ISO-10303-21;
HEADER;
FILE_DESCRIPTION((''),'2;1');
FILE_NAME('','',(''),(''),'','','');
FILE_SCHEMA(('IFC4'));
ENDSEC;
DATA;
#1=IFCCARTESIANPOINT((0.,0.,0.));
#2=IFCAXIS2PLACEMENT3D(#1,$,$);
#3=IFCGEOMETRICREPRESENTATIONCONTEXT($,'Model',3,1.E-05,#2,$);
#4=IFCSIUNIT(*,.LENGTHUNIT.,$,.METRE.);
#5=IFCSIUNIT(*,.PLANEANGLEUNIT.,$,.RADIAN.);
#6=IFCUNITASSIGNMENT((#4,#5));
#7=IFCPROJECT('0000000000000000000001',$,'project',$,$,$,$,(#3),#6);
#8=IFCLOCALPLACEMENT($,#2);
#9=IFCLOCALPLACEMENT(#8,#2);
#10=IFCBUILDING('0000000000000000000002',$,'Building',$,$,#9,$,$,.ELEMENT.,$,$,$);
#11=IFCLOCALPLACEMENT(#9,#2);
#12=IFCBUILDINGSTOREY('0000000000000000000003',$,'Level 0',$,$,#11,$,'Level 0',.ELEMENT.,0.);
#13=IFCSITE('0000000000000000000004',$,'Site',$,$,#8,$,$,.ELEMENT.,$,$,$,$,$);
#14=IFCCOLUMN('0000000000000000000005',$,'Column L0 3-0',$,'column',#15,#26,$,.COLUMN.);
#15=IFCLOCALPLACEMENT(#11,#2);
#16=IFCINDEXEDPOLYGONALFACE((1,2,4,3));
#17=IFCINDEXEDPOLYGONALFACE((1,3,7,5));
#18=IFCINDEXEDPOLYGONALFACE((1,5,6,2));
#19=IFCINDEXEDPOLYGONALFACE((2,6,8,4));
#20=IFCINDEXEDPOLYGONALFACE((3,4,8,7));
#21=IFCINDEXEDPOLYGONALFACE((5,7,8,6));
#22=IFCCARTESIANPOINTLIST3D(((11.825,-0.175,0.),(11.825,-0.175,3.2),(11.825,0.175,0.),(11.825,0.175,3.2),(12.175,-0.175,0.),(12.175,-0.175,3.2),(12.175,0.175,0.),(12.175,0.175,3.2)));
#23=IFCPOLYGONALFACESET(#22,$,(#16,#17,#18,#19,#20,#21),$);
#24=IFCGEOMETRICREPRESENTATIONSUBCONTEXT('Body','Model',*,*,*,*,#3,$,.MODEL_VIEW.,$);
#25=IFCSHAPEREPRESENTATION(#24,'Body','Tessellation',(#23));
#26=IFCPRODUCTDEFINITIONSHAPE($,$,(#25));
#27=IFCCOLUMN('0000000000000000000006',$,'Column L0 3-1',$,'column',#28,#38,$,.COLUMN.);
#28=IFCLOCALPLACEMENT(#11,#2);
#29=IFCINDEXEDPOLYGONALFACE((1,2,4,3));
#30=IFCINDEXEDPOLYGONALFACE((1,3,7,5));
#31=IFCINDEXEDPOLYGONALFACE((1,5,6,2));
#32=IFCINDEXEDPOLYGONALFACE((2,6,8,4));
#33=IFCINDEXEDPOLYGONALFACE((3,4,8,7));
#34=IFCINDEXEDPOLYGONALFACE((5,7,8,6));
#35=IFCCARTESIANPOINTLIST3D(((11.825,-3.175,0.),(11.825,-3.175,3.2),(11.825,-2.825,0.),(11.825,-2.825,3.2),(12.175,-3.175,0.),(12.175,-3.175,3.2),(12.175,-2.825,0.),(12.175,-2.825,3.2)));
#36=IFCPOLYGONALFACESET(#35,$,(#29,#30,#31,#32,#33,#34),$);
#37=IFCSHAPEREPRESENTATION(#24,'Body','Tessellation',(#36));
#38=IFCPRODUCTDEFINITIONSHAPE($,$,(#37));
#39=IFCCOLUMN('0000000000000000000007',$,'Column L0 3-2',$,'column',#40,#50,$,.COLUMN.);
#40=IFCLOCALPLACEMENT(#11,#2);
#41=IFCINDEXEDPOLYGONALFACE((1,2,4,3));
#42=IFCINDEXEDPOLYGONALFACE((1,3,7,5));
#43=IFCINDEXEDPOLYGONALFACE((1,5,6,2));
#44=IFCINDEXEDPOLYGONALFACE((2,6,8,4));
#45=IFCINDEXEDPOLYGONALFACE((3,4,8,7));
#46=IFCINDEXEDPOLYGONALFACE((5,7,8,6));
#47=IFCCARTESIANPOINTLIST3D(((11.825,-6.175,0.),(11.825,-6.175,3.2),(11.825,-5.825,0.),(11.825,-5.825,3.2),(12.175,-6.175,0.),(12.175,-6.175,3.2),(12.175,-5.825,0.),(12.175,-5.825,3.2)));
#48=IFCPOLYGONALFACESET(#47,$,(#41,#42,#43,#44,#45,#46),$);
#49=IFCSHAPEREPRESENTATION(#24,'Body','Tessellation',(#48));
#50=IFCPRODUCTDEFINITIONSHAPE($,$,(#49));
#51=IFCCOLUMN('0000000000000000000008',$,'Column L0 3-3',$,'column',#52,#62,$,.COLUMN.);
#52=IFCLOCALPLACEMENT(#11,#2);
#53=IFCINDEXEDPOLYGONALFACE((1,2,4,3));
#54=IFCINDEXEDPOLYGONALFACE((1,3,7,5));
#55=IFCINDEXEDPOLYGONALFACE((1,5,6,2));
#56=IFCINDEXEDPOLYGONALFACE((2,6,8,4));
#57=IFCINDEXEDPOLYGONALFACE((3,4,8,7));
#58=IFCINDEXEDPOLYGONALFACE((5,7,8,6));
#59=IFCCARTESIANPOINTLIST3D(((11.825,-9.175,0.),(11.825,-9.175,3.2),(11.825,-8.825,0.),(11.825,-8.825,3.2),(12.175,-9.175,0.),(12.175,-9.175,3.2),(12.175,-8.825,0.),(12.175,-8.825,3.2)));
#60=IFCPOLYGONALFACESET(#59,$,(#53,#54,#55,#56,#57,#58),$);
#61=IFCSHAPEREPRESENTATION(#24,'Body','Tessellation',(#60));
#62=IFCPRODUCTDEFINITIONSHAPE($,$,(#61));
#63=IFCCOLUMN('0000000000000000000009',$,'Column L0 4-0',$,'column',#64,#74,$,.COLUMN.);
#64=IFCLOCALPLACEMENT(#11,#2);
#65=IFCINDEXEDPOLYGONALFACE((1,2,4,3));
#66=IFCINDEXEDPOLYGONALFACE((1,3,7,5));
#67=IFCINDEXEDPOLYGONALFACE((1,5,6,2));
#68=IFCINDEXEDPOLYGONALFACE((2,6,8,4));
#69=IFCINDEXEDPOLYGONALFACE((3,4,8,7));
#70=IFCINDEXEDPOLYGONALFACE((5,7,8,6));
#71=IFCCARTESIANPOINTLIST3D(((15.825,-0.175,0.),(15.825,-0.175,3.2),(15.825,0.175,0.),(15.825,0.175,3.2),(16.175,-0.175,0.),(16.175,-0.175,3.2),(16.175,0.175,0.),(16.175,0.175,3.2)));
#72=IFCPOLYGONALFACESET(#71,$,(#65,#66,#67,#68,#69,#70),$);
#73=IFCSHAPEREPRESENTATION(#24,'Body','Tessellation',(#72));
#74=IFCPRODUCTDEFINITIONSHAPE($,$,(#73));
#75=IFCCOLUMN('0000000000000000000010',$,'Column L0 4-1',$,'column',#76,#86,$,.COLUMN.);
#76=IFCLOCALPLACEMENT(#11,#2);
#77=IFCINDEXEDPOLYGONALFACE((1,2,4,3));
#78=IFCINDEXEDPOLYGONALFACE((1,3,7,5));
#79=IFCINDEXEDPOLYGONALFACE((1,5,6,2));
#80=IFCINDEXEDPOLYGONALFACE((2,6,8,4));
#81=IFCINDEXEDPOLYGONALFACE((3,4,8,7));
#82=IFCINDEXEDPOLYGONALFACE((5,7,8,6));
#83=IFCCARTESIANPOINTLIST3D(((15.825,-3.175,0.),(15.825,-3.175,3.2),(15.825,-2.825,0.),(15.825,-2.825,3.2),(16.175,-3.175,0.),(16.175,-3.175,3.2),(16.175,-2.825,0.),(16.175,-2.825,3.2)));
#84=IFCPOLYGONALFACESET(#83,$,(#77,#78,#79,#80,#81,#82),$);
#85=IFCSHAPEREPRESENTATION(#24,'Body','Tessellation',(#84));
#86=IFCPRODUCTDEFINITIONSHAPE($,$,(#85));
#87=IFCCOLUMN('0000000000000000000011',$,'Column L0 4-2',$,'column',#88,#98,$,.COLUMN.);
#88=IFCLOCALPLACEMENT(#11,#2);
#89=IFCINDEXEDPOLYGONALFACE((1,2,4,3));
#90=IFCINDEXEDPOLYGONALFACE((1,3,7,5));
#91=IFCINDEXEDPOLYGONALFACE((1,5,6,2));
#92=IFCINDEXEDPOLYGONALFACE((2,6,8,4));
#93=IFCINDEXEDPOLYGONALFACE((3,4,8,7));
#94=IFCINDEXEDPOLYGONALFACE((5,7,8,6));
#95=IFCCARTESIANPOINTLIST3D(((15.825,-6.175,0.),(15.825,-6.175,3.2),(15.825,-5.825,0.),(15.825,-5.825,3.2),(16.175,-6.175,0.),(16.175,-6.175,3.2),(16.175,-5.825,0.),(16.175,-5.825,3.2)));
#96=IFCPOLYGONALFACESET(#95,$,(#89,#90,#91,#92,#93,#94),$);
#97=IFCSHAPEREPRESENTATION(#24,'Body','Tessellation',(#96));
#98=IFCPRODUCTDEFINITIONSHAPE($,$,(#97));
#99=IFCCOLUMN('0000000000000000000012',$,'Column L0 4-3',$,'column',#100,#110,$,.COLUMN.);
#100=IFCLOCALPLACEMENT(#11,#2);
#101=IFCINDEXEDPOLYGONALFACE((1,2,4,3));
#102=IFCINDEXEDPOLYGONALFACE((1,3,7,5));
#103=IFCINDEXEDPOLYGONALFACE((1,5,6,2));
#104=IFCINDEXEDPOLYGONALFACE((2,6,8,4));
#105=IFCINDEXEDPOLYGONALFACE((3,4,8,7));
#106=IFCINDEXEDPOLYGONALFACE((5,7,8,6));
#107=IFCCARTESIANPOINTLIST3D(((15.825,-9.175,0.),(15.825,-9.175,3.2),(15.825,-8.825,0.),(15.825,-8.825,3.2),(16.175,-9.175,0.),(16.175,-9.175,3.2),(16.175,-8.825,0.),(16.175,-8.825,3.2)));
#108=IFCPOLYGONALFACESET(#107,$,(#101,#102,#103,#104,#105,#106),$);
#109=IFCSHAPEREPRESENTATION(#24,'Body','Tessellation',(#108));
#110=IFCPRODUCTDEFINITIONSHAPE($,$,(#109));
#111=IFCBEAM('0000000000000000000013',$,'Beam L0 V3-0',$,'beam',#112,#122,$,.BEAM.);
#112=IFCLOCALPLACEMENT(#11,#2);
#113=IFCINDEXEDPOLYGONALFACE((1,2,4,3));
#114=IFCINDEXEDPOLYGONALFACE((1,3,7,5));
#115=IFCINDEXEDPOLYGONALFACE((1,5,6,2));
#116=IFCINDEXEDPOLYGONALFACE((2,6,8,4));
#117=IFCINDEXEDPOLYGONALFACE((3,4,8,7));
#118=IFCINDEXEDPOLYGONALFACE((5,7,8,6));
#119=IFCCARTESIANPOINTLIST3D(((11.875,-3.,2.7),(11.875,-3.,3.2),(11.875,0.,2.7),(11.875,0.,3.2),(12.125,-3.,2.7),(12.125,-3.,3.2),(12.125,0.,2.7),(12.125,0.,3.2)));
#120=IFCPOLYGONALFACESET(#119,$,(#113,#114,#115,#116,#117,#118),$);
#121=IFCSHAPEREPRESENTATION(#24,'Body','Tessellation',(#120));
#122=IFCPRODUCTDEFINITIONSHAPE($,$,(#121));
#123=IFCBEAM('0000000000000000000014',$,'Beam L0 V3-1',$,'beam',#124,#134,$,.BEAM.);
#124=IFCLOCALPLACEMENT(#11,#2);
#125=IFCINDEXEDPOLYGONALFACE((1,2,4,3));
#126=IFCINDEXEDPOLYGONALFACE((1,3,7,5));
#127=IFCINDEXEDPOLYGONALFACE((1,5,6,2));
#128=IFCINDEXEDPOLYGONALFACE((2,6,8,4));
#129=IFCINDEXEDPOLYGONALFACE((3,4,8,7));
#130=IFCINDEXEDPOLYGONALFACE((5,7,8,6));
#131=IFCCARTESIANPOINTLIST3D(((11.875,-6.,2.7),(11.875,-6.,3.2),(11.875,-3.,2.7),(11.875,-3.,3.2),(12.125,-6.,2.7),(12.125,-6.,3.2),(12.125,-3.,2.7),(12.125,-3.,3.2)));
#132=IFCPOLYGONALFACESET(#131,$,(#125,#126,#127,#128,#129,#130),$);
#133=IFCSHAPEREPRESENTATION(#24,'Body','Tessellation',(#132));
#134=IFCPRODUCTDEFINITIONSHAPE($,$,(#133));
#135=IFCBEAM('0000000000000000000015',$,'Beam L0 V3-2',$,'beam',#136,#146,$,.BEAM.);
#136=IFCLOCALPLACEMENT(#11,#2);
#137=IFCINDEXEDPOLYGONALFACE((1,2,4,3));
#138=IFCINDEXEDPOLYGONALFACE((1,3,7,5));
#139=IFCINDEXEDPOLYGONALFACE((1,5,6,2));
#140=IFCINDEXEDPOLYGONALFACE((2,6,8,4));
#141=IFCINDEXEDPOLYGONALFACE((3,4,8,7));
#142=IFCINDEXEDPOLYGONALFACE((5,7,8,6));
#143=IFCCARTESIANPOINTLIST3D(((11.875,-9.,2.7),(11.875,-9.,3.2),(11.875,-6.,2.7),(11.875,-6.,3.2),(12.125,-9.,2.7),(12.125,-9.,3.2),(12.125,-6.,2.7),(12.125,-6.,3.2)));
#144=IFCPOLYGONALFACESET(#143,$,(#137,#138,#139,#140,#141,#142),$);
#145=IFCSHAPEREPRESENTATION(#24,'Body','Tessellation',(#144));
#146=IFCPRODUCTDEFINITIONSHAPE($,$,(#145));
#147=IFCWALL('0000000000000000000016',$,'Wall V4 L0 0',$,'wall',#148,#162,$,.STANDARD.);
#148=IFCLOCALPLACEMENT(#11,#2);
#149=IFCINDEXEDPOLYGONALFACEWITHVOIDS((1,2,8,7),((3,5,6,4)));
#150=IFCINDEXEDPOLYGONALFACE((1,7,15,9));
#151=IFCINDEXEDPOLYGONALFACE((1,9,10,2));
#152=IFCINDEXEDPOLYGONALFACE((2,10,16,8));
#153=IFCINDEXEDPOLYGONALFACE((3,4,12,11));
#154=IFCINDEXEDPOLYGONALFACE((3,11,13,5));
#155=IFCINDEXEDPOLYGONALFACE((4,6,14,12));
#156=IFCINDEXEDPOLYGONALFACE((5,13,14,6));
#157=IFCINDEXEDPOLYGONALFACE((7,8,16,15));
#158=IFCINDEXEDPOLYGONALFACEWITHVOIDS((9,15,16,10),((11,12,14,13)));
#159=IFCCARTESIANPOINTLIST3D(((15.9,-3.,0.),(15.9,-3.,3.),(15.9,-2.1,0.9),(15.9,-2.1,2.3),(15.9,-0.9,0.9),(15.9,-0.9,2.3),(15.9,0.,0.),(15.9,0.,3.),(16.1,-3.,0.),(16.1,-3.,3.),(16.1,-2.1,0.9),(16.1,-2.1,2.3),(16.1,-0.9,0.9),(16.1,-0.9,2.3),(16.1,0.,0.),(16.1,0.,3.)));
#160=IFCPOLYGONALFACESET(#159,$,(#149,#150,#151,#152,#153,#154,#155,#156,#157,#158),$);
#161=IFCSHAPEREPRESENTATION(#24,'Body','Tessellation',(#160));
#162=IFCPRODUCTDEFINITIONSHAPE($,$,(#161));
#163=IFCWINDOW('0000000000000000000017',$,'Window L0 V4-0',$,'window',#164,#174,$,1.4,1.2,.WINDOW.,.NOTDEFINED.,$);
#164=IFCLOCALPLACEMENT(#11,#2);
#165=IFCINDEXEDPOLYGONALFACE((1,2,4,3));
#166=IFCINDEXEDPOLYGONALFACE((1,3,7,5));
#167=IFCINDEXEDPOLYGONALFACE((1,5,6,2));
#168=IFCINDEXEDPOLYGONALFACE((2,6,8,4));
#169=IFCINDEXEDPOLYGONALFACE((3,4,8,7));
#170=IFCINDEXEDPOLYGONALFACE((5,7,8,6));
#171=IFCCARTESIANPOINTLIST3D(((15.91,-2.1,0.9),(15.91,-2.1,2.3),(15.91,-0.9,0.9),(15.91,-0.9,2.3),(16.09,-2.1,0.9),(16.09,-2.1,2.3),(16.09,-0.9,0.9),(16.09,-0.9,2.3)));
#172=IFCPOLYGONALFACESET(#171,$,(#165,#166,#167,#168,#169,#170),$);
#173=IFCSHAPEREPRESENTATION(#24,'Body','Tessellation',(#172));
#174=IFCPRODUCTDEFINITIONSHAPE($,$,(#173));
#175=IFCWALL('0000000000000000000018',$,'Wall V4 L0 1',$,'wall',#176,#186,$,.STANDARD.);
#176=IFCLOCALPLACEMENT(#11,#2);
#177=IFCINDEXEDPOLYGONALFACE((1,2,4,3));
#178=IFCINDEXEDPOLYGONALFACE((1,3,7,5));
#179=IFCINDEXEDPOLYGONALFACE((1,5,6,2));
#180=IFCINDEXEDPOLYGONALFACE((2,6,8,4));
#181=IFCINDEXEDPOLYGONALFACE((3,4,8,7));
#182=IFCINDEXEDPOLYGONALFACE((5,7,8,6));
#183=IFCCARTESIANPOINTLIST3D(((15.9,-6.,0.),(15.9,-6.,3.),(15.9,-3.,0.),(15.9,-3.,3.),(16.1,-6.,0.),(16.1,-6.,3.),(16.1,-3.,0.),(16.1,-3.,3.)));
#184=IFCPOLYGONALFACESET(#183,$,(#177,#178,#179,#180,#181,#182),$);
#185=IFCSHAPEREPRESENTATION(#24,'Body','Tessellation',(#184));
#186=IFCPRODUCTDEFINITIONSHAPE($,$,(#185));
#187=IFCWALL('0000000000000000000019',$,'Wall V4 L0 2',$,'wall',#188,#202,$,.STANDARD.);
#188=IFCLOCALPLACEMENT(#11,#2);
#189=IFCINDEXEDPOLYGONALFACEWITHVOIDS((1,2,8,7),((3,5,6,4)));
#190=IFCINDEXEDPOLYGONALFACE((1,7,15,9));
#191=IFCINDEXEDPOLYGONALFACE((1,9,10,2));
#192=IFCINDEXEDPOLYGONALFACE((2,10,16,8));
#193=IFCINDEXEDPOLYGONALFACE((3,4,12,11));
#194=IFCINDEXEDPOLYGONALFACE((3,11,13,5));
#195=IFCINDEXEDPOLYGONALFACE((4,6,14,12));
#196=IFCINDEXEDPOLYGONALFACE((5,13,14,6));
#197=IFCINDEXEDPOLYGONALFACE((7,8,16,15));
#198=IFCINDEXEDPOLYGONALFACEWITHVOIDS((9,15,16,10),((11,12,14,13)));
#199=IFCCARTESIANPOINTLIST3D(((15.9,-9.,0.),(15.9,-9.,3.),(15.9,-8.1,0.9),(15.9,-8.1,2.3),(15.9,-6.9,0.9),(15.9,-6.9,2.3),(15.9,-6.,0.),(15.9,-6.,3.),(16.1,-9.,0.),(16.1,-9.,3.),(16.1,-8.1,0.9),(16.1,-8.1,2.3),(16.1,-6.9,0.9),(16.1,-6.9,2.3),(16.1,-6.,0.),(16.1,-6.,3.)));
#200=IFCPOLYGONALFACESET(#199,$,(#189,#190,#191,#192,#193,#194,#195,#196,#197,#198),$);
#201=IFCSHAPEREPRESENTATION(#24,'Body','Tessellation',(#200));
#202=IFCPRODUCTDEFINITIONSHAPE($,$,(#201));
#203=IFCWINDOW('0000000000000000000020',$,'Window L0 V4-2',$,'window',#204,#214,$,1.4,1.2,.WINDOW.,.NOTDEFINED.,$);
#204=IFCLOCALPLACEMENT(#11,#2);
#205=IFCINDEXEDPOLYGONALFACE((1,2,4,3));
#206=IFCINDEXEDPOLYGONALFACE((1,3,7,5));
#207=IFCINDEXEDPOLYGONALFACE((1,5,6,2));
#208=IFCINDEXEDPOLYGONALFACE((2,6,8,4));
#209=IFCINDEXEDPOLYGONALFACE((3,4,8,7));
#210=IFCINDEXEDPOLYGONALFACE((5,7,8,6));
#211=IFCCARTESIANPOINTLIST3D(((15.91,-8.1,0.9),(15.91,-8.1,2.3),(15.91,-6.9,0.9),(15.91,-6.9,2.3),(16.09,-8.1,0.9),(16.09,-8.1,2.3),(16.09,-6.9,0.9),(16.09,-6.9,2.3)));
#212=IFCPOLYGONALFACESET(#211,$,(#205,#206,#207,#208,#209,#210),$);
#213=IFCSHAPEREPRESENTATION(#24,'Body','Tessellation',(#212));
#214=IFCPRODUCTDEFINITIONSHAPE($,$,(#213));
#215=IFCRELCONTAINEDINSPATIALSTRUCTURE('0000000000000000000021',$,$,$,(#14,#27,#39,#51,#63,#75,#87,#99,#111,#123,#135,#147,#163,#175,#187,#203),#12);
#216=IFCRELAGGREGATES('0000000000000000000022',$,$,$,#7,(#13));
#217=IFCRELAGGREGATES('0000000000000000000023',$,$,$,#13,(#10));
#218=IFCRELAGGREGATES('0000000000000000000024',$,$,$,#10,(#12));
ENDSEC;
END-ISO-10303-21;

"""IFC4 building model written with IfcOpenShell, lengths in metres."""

from ifc_helpers import new_model, si_unit, frame, frame_2d, origin, origin_2d, place, context, subcontext, project, spatial, rectangle, extrude, element, fill, save


model = new_model("IFC4")

# Units and contexts
model_context = context("Model", 3, precision=1e-05, world=origin())
body_context = subcontext(model_context, "Body", "Model", "MODEL_VIEW")
ifc_project = project(units=[si_unit("LENGTHUNIT", "METRE"), si_unit("PLANEANGLEUNIT", "RADIAN")], contexts=[model_context])

# Site, building, storey
site_placement = place(None, origin())
site = spatial("IfcSite", under=ifc_project, at=site_placement, Name="Site", CompositionType="ELEMENT")
building_placement = place(site_placement, origin())
building = spatial("IfcBuilding", under=site, at=building_placement, Name="Building", CompositionType="ELEMENT")
storey_placement = place(building_placement, origin())
storey = spatial("IfcBuildingStorey", under=building, at=storey_placement, Name="Level 0", LongName="Level 0", CompositionType="ELEMENT", Elevation=0.0)

# Columns
for number, where, name in (
    (1, (12.0, 0.0, 0.0), "Column L0 3-0"),
    (2, (12.0, -3.0, 0.0), "Column L0 3-1"),
    (3, (12.0, -6.0, 0.0), "Column L0 3-2"),
    (4, (12.0, -9.0, 0.0), "Column L0 3-3"),
    (5, (16.0, 0.0, 0.0), "Column L0 4-0"),
    (6, (16.0, -3.0, 0.0), "Column L0 4-1"),
    (7, (16.0, -6.0, 0.0), "Column L0 4-2"),
    (8, (16.0, -9.0, 0.0), "Column L0 4-3"),
):
    element("IfcColumn", number, at=place(storey_placement, frame(where)), inside=storey, Name=name, ObjectType="column", PredefinedType="COLUMN", context=body_context, shape_type="SweptSolid", body=[
        extrude(rectangle(XDim=0.35, YDim=0.35, at=origin_2d()), origin(), (0.0, 0.0, 1.0), 3.2),
    ])

# Beams
for number, where, z_axis, x_axis, name in (
    (9, (12.0, 0.0, 2.95), (0.0, -1.0, 0.0), (0.0, 0.0, 1.0), "Beam L0 V3-0"),
    (10, (12.0, -3.0, 2.95), (0.0, -1.0, 0.0), (0.0, 0.0, 1.0), "Beam L0 V3-1"),
    (11, (12.0, -6.0, 2.95), (0.0, -1.0, 0.0), (0.0, 0.0, 1.0), "Beam L0 V3-2"),
):
    element("IfcBeam", number, at=place(storey_placement, frame(where, z_axis=z_axis, x_axis=x_axis)), inside=storey, Name=name, ObjectType="beam", PredefinedType="BEAM", context=body_context, shape_type="SweptSolid", body=[
        extrude(rectangle(XDim=0.5, YDim=0.25, at=origin_2d()), origin(), (0.0, 0.0, 1.0), 3.0),
    ])

# Wall, opening, window
wall_1_placement = place(storey_placement, frame((16.0, 0.0, 0.0), z_axis=(0.0, 0.0, 1.0), x_axis=(0.0, -1.0, 0.0)))
wall_1 = element("IfcWall", 12, at=wall_1_placement, inside=storey, Name="Wall V4 L0 0", ObjectType="wall", PredefinedType="STANDARD", context=body_context, shape_type="SweptSolid", body=[
    extrude(rectangle(XDim=3.0, YDim=0.2, at=frame_2d((1.5, 0.0))), origin(), (0.0, 0.0, 1.0), 3.0),
])
opening_1_placement = place(storey_placement, frame((16.0, -1.5, 0.9), z_axis=(0.0, 0.0, 1.0), x_axis=(0.0, -1.0, 0.0)))
opening_1 = element("IfcOpeningElement", 13, at=opening_1_placement, cuts=wall_1, ObjectType="Opening", PredefinedType="OPENING", context=body_context, shape_type="SweptSolid", body=[
    extrude(rectangle(XDim=1.2, YDim=0.22, at=origin_2d()), origin(), (0.0, 0.0, 1.0), 1.4),
])
window_1_placement = place(storey_placement, frame((16.0, -1.5, 0.9), z_axis=(0.0, 0.0, 1.0), x_axis=(0.0, -1.0, 0.0)))
window_1 = element("IfcWindow", 14, at=window_1_placement, inside=storey, Name="Window L0 V4-0", ObjectType="window", OverallHeight=1.4, OverallWidth=1.2, PartitioningType="NOTDEFINED", PredefinedType="WINDOW", context=body_context, shape_type="SweptSolid", body=[
    extrude(rectangle(XDim=1.2, YDim=0.18, at=origin_2d()), origin(), (0.0, 0.0, 1.0), 1.4),
])
fill(opening_1, window_1)

# Wall
wall_2_placement = place(storey_placement, frame((16.0, -3.0, 0.0), z_axis=(0.0, 0.0, 1.0), x_axis=(0.0, -1.0, 0.0)))
element("IfcWall", 15, at=wall_2_placement, inside=storey, Name="Wall V4 L0 1", ObjectType="wall", PredefinedType="STANDARD", context=body_context, shape_type="SweptSolid", body=[
    extrude(rectangle(XDim=3.0, YDim=0.2, at=frame_2d((1.5, 0.0))), origin(), (0.0, 0.0, 1.0), 3.0),
])

# Wall, opening, window
wall_3_placement = place(storey_placement, frame((16.0, -6.0, 0.0), z_axis=(0.0, 0.0, 1.0), x_axis=(0.0, -1.0, 0.0)))
wall_3 = element("IfcWall", 16, at=wall_3_placement, inside=storey, Name="Wall V4 L0 2", ObjectType="wall", PredefinedType="STANDARD", context=body_context, shape_type="SweptSolid", body=[
    extrude(rectangle(XDim=3.0, YDim=0.2, at=frame_2d((1.5, 0.0))), origin(), (0.0, 0.0, 1.0), 3.0),
])
opening_2_placement = place(storey_placement, frame((16.0, -7.5, 0.9), z_axis=(0.0, 0.0, 1.0), x_axis=(0.0, -1.0, 0.0)))
opening_2 = element("IfcOpeningElement", 17, at=opening_2_placement, cuts=wall_3, ObjectType="Opening", PredefinedType="OPENING", context=body_context, shape_type="SweptSolid", body=[
    extrude(rectangle(XDim=1.2, YDim=0.22, at=origin_2d()), origin(), (0.0, 0.0, 1.0), 1.4),
])
window_2_placement = place(storey_placement, frame((16.0, -7.5, 0.9), z_axis=(0.0, 0.0, 1.0), x_axis=(0.0, -1.0, 0.0)))
window_2 = element("IfcWindow", 18, at=window_2_placement, inside=storey, Name="Window L0 V4-2", ObjectType="window", OverallHeight=1.4, OverallWidth=1.2, PartitioningType="NOTDEFINED", PredefinedType="WINDOW", context=body_context, shape_type="SweptSolid", body=[
    extrude(rectangle(XDim=1.2, YDim=0.18, at=origin_2d()), origin(), (0.0, 0.0, 1.0), 1.4),
])
fill(opening_2, window_2)

save(model, "model.ifc")
